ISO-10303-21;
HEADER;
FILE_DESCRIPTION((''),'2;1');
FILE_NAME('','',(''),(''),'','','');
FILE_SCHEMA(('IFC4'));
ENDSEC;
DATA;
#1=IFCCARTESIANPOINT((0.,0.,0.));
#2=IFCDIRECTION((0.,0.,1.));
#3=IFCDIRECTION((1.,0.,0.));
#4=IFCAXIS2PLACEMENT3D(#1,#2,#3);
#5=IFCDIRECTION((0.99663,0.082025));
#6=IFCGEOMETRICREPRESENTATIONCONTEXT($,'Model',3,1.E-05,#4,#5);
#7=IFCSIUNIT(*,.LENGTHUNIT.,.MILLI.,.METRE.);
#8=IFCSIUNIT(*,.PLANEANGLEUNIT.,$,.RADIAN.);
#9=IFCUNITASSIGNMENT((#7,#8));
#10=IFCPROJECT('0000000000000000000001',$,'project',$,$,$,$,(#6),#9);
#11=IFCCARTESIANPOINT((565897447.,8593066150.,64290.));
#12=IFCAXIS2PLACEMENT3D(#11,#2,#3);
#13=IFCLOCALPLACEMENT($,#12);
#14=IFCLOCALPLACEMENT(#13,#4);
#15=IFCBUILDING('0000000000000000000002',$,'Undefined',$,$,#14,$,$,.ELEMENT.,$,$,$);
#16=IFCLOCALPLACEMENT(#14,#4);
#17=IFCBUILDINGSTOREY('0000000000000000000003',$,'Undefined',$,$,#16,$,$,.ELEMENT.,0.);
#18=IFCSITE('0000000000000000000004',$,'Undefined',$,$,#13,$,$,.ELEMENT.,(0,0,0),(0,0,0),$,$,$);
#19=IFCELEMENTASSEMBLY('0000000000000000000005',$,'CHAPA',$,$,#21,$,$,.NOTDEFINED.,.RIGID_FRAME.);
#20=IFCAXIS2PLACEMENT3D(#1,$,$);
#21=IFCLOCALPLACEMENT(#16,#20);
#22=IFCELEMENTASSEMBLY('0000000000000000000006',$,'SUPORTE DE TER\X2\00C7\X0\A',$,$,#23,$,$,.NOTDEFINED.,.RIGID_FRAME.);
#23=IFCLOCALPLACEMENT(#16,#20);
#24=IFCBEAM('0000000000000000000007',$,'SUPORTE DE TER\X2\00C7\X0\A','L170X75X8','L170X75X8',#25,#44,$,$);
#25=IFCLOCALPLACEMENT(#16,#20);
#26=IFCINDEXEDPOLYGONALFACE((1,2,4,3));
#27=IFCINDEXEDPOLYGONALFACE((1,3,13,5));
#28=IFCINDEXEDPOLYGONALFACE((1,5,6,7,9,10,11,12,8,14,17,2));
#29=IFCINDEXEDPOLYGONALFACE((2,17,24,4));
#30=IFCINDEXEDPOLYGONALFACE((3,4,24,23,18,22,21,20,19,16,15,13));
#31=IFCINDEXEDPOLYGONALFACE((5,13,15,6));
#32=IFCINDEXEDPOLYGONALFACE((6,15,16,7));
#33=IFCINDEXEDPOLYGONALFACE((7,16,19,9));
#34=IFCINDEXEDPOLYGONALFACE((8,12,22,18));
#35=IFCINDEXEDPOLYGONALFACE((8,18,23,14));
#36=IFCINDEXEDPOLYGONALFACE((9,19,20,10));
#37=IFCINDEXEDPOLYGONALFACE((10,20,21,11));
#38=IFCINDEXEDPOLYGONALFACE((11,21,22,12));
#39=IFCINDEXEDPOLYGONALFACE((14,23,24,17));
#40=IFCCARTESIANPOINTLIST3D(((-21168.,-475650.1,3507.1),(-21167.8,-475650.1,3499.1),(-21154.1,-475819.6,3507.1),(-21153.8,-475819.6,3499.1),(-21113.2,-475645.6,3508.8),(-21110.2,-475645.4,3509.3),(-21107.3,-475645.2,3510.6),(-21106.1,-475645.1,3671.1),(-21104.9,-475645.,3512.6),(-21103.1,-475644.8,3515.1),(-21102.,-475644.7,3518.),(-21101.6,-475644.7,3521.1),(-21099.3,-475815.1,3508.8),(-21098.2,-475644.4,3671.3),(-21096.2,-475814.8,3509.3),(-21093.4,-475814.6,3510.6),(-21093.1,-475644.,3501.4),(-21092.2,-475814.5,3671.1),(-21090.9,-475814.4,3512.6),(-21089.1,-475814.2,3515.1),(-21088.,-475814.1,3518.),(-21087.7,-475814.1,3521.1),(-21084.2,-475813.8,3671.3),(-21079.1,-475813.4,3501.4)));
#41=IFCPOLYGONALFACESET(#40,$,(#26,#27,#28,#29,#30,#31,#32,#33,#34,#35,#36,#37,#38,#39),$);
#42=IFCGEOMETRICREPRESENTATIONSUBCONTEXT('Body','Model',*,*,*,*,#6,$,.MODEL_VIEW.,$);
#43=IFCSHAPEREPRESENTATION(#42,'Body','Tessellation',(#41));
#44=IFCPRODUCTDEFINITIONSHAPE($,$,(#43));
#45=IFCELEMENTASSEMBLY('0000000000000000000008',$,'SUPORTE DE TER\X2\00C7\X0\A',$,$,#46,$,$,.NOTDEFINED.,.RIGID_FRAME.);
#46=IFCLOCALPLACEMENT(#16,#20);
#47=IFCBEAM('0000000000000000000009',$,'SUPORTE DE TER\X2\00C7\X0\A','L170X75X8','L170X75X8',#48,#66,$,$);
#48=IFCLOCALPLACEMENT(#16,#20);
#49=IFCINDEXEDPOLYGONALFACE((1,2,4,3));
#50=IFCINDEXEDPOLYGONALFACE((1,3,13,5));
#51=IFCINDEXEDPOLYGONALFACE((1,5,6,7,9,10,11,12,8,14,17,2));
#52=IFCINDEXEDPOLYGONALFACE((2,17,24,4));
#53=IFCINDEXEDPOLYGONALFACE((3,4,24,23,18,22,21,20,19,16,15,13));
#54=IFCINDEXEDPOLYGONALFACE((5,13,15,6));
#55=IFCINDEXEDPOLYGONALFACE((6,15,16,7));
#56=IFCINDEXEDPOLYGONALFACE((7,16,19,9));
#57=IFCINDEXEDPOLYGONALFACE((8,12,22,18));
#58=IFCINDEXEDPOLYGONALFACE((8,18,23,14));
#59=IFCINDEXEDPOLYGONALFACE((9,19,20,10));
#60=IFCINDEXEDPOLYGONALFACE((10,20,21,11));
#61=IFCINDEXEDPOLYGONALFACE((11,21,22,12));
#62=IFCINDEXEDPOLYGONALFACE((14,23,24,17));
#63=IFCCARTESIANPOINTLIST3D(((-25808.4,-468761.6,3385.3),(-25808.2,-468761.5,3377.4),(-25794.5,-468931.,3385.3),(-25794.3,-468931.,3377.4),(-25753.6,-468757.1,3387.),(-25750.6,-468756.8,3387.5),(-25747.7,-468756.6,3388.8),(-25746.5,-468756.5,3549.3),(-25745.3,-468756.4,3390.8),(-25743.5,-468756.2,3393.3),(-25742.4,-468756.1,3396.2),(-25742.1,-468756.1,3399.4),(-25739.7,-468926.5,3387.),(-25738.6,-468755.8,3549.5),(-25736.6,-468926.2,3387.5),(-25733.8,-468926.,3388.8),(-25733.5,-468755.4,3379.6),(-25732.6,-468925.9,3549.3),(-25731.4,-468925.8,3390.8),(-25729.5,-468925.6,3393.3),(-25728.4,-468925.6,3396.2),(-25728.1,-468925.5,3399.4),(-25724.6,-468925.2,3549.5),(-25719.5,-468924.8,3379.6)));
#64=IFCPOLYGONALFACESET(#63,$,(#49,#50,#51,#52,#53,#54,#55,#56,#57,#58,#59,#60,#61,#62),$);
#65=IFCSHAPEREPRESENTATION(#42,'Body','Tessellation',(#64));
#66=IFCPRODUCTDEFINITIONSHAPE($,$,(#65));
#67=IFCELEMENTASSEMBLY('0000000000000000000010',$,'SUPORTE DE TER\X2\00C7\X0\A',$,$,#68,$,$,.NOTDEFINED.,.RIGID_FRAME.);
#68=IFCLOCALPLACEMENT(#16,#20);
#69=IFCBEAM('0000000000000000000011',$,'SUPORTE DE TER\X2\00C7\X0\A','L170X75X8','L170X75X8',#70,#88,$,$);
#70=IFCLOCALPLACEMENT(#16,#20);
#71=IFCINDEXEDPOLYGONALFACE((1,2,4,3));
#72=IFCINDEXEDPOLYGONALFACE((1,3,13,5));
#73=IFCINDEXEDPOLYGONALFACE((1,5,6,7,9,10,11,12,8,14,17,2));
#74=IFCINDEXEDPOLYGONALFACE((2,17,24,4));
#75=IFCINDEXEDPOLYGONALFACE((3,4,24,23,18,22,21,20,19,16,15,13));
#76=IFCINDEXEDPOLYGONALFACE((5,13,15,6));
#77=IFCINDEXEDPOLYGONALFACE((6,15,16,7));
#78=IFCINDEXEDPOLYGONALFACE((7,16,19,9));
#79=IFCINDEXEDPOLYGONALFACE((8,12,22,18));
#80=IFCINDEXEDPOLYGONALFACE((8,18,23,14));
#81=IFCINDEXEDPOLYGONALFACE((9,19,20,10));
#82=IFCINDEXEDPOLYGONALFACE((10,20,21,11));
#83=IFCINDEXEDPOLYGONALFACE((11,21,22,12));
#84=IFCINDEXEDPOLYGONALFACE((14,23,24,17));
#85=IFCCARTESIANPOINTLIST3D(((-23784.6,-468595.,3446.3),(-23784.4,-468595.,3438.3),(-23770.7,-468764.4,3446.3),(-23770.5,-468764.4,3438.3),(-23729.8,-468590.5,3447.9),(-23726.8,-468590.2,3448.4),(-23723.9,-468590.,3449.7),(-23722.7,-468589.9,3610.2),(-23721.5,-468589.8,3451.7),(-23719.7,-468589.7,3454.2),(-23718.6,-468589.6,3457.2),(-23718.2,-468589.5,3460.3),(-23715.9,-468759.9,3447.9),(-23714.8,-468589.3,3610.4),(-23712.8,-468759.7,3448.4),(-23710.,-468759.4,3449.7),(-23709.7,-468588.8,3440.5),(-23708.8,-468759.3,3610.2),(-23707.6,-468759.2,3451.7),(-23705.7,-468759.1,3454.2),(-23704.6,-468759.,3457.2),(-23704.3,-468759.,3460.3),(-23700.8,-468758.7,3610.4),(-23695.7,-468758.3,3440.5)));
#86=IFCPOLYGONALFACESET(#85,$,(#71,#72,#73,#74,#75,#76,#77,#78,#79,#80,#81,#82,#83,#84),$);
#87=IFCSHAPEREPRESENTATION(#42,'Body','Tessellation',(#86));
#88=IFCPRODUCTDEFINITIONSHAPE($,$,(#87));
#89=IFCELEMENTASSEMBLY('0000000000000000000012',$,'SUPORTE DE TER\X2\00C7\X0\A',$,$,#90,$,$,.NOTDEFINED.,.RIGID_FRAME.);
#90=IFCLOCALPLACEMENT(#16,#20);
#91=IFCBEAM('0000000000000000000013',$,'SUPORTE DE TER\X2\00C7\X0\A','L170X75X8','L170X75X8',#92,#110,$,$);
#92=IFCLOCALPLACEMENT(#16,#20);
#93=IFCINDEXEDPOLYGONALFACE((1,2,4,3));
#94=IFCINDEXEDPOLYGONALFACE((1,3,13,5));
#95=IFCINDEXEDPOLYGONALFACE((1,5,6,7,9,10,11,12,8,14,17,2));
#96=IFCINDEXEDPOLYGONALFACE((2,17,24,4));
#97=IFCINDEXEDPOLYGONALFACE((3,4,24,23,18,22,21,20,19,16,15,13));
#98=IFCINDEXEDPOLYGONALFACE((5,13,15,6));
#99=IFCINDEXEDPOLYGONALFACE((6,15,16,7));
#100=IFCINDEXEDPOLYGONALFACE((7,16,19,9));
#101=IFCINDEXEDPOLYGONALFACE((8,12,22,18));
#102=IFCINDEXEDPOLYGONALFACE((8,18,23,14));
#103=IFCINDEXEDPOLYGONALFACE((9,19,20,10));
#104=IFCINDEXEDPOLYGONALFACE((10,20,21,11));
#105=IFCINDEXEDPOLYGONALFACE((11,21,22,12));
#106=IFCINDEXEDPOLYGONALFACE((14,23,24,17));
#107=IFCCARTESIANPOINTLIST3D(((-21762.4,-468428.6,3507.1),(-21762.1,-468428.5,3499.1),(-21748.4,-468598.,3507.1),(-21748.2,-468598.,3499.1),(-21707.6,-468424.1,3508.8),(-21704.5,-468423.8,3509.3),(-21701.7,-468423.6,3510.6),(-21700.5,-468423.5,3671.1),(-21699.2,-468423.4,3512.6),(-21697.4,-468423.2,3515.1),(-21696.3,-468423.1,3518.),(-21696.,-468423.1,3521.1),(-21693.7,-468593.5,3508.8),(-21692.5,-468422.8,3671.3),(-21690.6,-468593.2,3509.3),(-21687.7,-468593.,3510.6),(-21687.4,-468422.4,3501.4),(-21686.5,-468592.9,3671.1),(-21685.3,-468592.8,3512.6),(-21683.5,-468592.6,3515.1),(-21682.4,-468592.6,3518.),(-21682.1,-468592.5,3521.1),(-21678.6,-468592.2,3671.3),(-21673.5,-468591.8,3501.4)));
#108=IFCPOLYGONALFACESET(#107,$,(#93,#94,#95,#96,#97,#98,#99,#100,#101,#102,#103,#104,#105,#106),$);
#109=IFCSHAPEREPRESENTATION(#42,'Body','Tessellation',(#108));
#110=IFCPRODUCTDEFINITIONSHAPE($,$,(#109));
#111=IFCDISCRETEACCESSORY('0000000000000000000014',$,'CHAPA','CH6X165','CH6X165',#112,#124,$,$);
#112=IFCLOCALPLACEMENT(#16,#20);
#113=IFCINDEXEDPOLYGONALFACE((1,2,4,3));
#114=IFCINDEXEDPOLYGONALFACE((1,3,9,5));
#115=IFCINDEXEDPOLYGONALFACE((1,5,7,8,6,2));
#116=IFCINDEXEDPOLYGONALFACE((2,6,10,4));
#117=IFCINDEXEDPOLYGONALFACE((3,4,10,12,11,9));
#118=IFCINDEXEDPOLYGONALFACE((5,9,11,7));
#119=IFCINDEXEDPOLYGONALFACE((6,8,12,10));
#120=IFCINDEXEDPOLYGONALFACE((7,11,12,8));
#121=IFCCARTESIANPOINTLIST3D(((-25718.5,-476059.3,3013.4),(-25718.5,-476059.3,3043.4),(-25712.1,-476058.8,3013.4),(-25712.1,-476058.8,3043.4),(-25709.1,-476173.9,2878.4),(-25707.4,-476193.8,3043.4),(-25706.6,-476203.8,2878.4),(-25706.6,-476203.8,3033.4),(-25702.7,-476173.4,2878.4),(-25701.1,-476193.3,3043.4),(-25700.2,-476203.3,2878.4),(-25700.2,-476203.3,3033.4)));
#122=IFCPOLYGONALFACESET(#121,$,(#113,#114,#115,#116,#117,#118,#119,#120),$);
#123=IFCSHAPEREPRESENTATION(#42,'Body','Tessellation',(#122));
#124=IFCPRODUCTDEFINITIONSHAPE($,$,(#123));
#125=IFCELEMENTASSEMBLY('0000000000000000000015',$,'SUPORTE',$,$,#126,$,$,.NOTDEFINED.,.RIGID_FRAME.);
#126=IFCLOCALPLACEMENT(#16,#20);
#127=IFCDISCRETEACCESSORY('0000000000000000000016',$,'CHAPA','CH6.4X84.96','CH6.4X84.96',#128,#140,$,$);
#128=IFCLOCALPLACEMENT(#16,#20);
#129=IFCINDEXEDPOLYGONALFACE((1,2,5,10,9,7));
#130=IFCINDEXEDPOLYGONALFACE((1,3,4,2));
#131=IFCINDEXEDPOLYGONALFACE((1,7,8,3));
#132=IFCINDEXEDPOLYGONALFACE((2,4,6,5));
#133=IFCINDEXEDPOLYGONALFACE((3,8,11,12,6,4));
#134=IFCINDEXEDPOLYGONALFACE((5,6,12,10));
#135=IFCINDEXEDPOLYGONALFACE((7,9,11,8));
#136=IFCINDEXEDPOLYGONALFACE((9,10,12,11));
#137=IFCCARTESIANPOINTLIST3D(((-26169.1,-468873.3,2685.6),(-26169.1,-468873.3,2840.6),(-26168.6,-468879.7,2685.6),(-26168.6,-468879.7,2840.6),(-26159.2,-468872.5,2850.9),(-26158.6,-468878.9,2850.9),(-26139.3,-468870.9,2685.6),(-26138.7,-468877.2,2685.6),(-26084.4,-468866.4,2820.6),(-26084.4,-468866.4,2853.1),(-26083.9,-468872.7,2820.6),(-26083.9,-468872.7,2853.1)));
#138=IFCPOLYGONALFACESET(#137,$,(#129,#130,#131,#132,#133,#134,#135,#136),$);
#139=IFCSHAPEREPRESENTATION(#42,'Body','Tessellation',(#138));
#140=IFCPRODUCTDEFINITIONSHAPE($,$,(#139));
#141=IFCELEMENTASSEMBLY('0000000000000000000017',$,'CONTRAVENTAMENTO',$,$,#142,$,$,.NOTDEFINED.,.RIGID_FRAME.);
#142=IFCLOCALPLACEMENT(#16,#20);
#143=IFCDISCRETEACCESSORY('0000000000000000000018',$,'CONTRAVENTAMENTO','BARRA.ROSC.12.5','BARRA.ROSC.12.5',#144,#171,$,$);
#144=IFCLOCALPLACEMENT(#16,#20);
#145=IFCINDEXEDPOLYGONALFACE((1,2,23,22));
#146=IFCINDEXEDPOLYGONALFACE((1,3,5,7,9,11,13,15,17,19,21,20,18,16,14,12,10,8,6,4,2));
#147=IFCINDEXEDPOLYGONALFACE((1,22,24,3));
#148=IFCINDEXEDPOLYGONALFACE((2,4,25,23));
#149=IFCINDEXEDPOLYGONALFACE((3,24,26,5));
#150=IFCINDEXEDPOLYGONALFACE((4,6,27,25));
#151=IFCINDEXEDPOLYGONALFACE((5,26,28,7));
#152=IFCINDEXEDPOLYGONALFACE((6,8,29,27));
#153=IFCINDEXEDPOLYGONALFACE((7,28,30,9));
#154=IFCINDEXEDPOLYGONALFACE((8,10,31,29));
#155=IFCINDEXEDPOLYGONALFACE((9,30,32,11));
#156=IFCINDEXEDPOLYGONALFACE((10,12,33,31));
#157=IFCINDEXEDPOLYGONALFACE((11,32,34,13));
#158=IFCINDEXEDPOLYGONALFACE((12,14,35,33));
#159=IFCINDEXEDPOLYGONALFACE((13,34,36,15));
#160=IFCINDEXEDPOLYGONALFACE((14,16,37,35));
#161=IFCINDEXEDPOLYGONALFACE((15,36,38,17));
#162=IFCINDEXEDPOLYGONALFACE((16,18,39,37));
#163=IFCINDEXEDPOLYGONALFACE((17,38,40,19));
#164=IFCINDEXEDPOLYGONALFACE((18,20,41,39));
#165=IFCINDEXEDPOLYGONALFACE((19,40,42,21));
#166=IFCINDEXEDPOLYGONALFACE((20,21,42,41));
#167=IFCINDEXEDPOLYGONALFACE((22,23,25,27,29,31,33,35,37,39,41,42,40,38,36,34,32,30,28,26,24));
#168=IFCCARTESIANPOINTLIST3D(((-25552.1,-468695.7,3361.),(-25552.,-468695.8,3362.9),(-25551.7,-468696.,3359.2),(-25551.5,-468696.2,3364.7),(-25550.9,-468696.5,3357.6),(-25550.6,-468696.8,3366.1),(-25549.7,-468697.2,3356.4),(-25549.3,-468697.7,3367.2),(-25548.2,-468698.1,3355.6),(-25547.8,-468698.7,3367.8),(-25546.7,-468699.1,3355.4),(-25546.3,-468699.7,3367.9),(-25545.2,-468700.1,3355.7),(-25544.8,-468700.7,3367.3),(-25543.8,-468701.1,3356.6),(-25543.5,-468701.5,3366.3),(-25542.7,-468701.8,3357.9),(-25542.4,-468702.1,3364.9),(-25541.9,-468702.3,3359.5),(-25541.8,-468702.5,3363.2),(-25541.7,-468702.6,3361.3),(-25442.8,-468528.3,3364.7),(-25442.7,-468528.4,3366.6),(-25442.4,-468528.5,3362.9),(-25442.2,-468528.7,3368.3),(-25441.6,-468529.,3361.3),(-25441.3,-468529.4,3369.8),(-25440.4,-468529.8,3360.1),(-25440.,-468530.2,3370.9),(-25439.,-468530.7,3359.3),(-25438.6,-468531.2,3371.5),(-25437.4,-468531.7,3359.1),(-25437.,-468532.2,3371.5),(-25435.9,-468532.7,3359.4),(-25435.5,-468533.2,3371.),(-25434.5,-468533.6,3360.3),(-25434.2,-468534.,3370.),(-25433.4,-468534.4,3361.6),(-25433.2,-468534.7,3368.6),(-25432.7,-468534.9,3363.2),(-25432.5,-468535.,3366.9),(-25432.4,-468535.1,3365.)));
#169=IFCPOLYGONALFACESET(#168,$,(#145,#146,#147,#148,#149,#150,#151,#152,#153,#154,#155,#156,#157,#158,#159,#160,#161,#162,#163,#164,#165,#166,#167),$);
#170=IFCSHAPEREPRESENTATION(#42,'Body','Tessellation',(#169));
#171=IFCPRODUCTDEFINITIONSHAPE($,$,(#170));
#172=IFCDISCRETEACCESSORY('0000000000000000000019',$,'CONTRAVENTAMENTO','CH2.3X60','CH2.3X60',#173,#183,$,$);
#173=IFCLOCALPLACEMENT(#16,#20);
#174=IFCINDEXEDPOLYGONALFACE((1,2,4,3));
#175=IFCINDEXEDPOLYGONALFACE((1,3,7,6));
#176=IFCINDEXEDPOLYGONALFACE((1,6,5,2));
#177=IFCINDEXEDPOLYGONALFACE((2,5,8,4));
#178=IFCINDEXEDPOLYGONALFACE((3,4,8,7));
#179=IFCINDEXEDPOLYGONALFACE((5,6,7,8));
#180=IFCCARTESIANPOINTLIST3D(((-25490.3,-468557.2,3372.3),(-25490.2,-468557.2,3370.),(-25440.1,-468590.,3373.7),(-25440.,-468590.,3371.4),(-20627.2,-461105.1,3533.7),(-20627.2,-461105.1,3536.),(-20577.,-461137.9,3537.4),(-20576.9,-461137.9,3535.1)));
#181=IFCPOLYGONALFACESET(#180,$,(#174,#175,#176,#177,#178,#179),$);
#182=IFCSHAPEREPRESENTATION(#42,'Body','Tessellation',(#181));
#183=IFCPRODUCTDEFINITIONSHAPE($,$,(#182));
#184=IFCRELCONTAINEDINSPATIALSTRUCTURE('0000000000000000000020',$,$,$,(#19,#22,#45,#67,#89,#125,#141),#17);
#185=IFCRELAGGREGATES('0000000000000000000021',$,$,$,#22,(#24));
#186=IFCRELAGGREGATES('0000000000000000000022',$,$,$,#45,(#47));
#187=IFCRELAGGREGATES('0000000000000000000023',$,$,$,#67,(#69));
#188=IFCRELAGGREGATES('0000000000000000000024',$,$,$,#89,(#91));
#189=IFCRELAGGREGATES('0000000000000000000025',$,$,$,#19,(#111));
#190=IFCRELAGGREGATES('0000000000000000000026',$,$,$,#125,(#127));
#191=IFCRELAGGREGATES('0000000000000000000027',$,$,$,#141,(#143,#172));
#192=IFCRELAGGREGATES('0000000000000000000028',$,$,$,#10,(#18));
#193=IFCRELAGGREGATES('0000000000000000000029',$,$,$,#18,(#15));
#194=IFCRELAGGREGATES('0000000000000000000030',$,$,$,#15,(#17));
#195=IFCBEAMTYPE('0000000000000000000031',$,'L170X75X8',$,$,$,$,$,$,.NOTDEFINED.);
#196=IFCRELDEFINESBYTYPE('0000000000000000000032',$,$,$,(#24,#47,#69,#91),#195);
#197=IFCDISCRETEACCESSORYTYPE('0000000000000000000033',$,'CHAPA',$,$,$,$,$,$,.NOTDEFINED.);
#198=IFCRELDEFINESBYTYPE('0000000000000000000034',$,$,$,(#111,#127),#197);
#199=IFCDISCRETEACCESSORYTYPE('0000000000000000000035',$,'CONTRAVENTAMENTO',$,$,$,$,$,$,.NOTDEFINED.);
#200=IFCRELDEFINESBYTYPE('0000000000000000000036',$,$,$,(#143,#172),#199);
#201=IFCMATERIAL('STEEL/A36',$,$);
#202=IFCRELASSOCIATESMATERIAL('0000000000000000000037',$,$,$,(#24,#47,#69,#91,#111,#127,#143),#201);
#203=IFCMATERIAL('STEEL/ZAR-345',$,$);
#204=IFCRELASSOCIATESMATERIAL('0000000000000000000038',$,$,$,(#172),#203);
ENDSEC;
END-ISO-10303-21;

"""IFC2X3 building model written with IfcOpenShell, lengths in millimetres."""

from ifc_helpers import new_model, si_unit, direction, frame, origin_with_axes, origin_2d_with_axis, place, context, subcontext, project, spatial, polyline, circle, l_section, outline, extrude, material, type_object, element, aggregate, save


model = new_model("IFC2X3")

# Units and contexts
model_context = context("Model", 3, precision=1e-05, world=origin_with_axes(), true_north=direction((0.99663, 0.082025)))
body_context = subcontext(model_context, "Body", "Model", "MODEL_VIEW")
ifc_project = project(units=[si_unit("LENGTHUNIT", "METRE", prefix="MILLI"), si_unit("PLANEANGLEUNIT", "RADIAN")], contexts=[model_context])

# Site, building, storey
site_placement = place(None, frame((565897447.0, 8593066150.0, 64290.0), z_axis=(0.0, 0.0, 1.0), x_axis=(1.0, 0.0, 0.0)))
site = spatial("IfcSite", under=ifc_project, at=site_placement, Name="Undefined", CompositionType="ELEMENT", RefLatitude=(0, 0, 0), RefLongitude=(0, 0, 0))
building_placement = place(site_placement, origin_with_axes())
building = spatial("IfcBuilding", under=site, at=building_placement, Name="Undefined", CompositionType="ELEMENT")
storey_placement = place(building_placement, origin_with_axes())
storey = spatial("IfcBuildingStorey", under=building, at=storey_placement, Name="Undefined", CompositionType="ELEMENT", Elevation=0.0)

# Element assemblies, beams
assembly_1_placement = place(storey_placement, origin_with_axes())
assembly_1 = element("IfcElementAssembly", 1, at=assembly_1_placement, inside=storey, Name="CHAPA", AssemblyPlace="NOTDEFINED", PredefinedType="RIGID_FRAME")
ifc_material_1 = material(Name="STEEL/A36")
beam_type_1 = type_object("IfcBeamType", Name="L170X75X8", PredefinedType="NOTDEFINED")
assembly_2_placement = place(storey_placement, origin_with_axes())
assembly_2 = element("IfcElementAssembly", 2, at=assembly_2_placement, inside=storey, Name="SUPORTE DE TERÇA", AssemblyPlace="NOTDEFINED", PredefinedType="RIGID_FRAME")
beam_1_placement = place(assembly_2_placement, frame((-21133.0, -475647.3, 3585.2), z_axis=(-0.029885, -0.00246, 0.99955), x_axis=(0.082025, -0.99663, 0.0)))
beam_1 = element("IfcBeam", 3, at=beam_1_placement, type_object=beam_type_1, material=ifc_material_1, Name="SUPORTE DE TERÇA", Description="L170X75X8", ObjectType="L170X75X8", context=body_context, shape_type="SweptSolid", body=[
    extrude(l_section(Depth=170.0, Width=75.0, Thickness=8.0, FilletRadius=12.0, at=origin_2d_with_axis()), frame((170.0, 0.0, 0.0), z_axis=(-1.0, 0.0, 0.0), x_axis=(0.0, -1.0, 0.0)), (0.0, 0.0, 1.0), 170.0),
])
aggregate(assembly_2, [beam_1])
assembly_3_placement = place(storey_placement, origin_with_axes())
assembly_3 = element("IfcElementAssembly", 4, at=assembly_3_placement, inside=storey, Name="SUPORTE DE TERÇA", AssemblyPlace="NOTDEFINED", PredefinedType="RIGID_FRAME")
beam_2_placement = place(assembly_3_placement, frame((-25773.4, -468758.7, 3463.4), z_axis=(-0.029885, -0.00246, 0.99955), x_axis=(0.082025, -0.99663, 0.0)))
beam_2 = element("IfcBeam", 5, at=beam_2_placement, type_object=beam_type_1, material=ifc_material_1, Name="SUPORTE DE TERÇA", Description="L170X75X8", ObjectType="L170X75X8", context=body_context, shape_type="SweptSolid", body=[
    extrude(l_section(Depth=170.0, Width=75.0, Thickness=8.0, FilletRadius=12.0, at=origin_2d_with_axis()), frame((170.0, 0.0, 0.0), z_axis=(-1.0, 0.0, 0.0), x_axis=(0.0, -1.0, 0.0)), (0.0, 0.0, 1.0), 170.0),
])
aggregate(assembly_3, [beam_2])
assembly_4_placement = place(storey_placement, origin_with_axes())
assembly_4 = element("IfcElementAssembly", 6, at=assembly_4_placement, inside=storey, Name="SUPORTE DE TERÇA", AssemblyPlace="NOTDEFINED", PredefinedType="RIGID_FRAME")
beam_3_placement = place(assembly_4_placement, frame((-23749.6, -468592.1, 3524.4), z_axis=(-0.029885, -0.00246, 0.99955), x_axis=(0.082025, -0.99663, 0.0)))
beam_3 = element("IfcBeam", 7, at=beam_3_placement, type_object=beam_type_1, material=ifc_material_1, Name="SUPORTE DE TERÇA", Description="L170X75X8", ObjectType="L170X75X8", context=body_context, shape_type="SweptSolid", body=[
    extrude(l_section(Depth=170.0, Width=75.0, Thickness=8.0, FilletRadius=12.0, at=origin_2d_with_axis()), frame((170.0, 0.0, 0.0), z_axis=(-1.0, 0.0, 0.0), x_axis=(0.0, -1.0, 0.0)), (0.0, 0.0, 1.0), 170.0),
])
aggregate(assembly_4, [beam_3])
assembly_5_placement = place(storey_placement, origin_with_axes())
assembly_5 = element("IfcElementAssembly", 8, at=assembly_5_placement, inside=storey, Name="SUPORTE DE TERÇA", AssemblyPlace="NOTDEFINED", PredefinedType="RIGID_FRAME")
beam_4_placement = place(assembly_5_placement, frame((-21727.3, -468425.7, 3585.2), z_axis=(-0.029885, -0.00246, 0.99955), x_axis=(0.082025, -0.99663, 0.0)))
beam_4 = element("IfcBeam", 9, at=beam_4_placement, type_object=beam_type_1, material=ifc_material_1, Name="SUPORTE DE TERÇA", Description="L170X75X8", ObjectType="L170X75X8", context=body_context, shape_type="SweptSolid", body=[
    extrude(l_section(Depth=170.0, Width=75.0, Thickness=8.0, FilletRadius=12.0, at=origin_2d_with_axis()), frame((170.0, 0.0, 0.0), z_axis=(-1.0, 0.0, 0.0), x_axis=(0.0, -1.0, 0.0)), (0.0, 0.0, 1.0), 170.0),
])
aggregate(assembly_5, [beam_4])

# Discrete accessory
discrete_accessory_type_1 = type_object("IfcDiscreteAccessoryType", Name="CHAPA")
discrete_accessory_1_placement = place(assembly_1_placement, frame((-25703.4, -476203.5, 3043.4), z_axis=(0.99663, 0.082025, -0.000004), x_axis=(-0.000004, 0.0, -1.0)))
discrete_accessory_1 = element("IfcDiscreteAccessory", 10, at=discrete_accessory_1_placement, type_object=discrete_accessory_type_1, material=ifc_material_1, Name="CHAPA", Description="CH6X165", ObjectType="CH6X165", context=body_context, shape_type="SweptSolid", body=[
    extrude(outline(polyline([(0.0, 10.0), (10.0, 0.0), (165.0, 0.0), (165.0, 30.0), (30.0, 145.0), (0.0, 145.0), (0.0, 10.0)])), frame((0.0, 0.0, -3.2), z_axis=(0.0, 0.0, 1.0), x_axis=(1.0, 0.0, 0.0)), (0.0, 0.0, 1.0), 6.4),
])
aggregate(assembly_1, [discrete_accessory_1])

# Element assembly, discrete accessory
assembly_6_placement = place(storey_placement, origin_with_axes())
assembly_6 = element("IfcElementAssembly", 11, at=assembly_6_placement, inside=storey, Name="SUPORTE", AssemblyPlace="NOTDEFINED", PredefinedType="RIGID_FRAME")
discrete_accessory_2_placement = place(assembly_6_placement, frame((-26168.9, -468876.5, 2850.6), z_axis=(0.082025, -0.99663, 0.0), x_axis=(0.0, 0.0, -1.0)))
discrete_accessory_2 = element("IfcDiscreteAccessory", 12, at=discrete_accessory_2_placement, type_object=discrete_accessory_type_1, material=ifc_material_1, Name="CHAPA", Description="CH6.4X84.96", ObjectType="CH6.4X84.96", context=body_context, shape_type="SweptSolid", body=[
    extrude(outline(polyline([(-0.3, 10.0), (10.0, 0.0), (165.0, 0.0), (165.0, 30.0), (30.0, 85.0), (-2.5, 85.0), (-0.3, 10.0)])), frame((0.0, 0.0, -3.2), z_axis=(0.0, 0.0, 1.0), x_axis=(1.0, 0.0, 0.0)), (0.0, 0.0, 1.0), 6.4),
])
aggregate(assembly_6, [discrete_accessory_2])

# Element assembly, discrete accessories
assembly_7_placement = place(storey_placement, origin_with_axes())
assembly_7 = element("IfcElementAssembly", 13, at=assembly_7_placement, inside=storey, Name="CONTRAVENTAMENTO", AssemblyPlace="NOTDEFINED", PredefinedType="RIGID_FRAME")
discrete_accessory_type_2 = type_object("IfcDiscreteAccessoryType", Name="CONTRAVENTAMENTO")
discrete_accessory_3_placement = place(assembly_7_placement, frame((-25546.9, -468699.2, 3361.7), z_axis=(0.836984, -0.546715, 0.02368), x_axis=(0.546411, 0.837315, 0.018398)))
discrete_accessory_3 = element("IfcDiscreteAccessory", 14, at=discrete_accessory_3_placement, type_object=discrete_accessory_type_2, material=ifc_material_1, Name="CONTRAVENTAMENTO", Description="BARRA.ROSC.12.5", ObjectType="BARRA.ROSC.12.5", context=body_context, shape_type="SweptSolid", body=[
    extrude(circle(Radius=6.2, at=origin_2d_with_axis()), frame((200.0, 0.0, 0.0), z_axis=(-1.0, 0.0, 0.0), x_axis=(0.0, -1.0, 0.0)), (0.0, 0.0, 1.0), 200.0),
])
ifc_material_2 = material(Name="STEEL/ZAR-345")
discrete_accessory_4_placement = place(assembly_7_placement, frame((-25465.1, -468573.6, 3371.8), z_axis=(0.029885, 0.00246, -0.99955), x_axis=(0.546411, 0.837315, 0.018398)))
discrete_accessory_4 = element("IfcDiscreteAccessory", 15, at=discrete_accessory_4_placement, type_object=discrete_accessory_type_2, material=ifc_material_2, Name="CONTRAVENTAMENTO", Description="CH2.3X60", ObjectType="CH2.3X60", context=body_context, shape_type="SweptSolid", body=[
    extrude(outline(polyline([(8900.0, -30.0), (0.0, -30.0), (0.0, 30.0), (8900.0, 30.0), (8900.0, -30.0)])), frame((0.0, 0.0, -1.1), z_axis=(0.0, 0.0, 1.0), x_axis=(1.0, 0.0, 0.0)), (0.0, 0.0, 1.0), 2.3),
])
aggregate(assembly_7, [discrete_accessory_3, discrete_accessory_4])

save(model, "model.ifc")
